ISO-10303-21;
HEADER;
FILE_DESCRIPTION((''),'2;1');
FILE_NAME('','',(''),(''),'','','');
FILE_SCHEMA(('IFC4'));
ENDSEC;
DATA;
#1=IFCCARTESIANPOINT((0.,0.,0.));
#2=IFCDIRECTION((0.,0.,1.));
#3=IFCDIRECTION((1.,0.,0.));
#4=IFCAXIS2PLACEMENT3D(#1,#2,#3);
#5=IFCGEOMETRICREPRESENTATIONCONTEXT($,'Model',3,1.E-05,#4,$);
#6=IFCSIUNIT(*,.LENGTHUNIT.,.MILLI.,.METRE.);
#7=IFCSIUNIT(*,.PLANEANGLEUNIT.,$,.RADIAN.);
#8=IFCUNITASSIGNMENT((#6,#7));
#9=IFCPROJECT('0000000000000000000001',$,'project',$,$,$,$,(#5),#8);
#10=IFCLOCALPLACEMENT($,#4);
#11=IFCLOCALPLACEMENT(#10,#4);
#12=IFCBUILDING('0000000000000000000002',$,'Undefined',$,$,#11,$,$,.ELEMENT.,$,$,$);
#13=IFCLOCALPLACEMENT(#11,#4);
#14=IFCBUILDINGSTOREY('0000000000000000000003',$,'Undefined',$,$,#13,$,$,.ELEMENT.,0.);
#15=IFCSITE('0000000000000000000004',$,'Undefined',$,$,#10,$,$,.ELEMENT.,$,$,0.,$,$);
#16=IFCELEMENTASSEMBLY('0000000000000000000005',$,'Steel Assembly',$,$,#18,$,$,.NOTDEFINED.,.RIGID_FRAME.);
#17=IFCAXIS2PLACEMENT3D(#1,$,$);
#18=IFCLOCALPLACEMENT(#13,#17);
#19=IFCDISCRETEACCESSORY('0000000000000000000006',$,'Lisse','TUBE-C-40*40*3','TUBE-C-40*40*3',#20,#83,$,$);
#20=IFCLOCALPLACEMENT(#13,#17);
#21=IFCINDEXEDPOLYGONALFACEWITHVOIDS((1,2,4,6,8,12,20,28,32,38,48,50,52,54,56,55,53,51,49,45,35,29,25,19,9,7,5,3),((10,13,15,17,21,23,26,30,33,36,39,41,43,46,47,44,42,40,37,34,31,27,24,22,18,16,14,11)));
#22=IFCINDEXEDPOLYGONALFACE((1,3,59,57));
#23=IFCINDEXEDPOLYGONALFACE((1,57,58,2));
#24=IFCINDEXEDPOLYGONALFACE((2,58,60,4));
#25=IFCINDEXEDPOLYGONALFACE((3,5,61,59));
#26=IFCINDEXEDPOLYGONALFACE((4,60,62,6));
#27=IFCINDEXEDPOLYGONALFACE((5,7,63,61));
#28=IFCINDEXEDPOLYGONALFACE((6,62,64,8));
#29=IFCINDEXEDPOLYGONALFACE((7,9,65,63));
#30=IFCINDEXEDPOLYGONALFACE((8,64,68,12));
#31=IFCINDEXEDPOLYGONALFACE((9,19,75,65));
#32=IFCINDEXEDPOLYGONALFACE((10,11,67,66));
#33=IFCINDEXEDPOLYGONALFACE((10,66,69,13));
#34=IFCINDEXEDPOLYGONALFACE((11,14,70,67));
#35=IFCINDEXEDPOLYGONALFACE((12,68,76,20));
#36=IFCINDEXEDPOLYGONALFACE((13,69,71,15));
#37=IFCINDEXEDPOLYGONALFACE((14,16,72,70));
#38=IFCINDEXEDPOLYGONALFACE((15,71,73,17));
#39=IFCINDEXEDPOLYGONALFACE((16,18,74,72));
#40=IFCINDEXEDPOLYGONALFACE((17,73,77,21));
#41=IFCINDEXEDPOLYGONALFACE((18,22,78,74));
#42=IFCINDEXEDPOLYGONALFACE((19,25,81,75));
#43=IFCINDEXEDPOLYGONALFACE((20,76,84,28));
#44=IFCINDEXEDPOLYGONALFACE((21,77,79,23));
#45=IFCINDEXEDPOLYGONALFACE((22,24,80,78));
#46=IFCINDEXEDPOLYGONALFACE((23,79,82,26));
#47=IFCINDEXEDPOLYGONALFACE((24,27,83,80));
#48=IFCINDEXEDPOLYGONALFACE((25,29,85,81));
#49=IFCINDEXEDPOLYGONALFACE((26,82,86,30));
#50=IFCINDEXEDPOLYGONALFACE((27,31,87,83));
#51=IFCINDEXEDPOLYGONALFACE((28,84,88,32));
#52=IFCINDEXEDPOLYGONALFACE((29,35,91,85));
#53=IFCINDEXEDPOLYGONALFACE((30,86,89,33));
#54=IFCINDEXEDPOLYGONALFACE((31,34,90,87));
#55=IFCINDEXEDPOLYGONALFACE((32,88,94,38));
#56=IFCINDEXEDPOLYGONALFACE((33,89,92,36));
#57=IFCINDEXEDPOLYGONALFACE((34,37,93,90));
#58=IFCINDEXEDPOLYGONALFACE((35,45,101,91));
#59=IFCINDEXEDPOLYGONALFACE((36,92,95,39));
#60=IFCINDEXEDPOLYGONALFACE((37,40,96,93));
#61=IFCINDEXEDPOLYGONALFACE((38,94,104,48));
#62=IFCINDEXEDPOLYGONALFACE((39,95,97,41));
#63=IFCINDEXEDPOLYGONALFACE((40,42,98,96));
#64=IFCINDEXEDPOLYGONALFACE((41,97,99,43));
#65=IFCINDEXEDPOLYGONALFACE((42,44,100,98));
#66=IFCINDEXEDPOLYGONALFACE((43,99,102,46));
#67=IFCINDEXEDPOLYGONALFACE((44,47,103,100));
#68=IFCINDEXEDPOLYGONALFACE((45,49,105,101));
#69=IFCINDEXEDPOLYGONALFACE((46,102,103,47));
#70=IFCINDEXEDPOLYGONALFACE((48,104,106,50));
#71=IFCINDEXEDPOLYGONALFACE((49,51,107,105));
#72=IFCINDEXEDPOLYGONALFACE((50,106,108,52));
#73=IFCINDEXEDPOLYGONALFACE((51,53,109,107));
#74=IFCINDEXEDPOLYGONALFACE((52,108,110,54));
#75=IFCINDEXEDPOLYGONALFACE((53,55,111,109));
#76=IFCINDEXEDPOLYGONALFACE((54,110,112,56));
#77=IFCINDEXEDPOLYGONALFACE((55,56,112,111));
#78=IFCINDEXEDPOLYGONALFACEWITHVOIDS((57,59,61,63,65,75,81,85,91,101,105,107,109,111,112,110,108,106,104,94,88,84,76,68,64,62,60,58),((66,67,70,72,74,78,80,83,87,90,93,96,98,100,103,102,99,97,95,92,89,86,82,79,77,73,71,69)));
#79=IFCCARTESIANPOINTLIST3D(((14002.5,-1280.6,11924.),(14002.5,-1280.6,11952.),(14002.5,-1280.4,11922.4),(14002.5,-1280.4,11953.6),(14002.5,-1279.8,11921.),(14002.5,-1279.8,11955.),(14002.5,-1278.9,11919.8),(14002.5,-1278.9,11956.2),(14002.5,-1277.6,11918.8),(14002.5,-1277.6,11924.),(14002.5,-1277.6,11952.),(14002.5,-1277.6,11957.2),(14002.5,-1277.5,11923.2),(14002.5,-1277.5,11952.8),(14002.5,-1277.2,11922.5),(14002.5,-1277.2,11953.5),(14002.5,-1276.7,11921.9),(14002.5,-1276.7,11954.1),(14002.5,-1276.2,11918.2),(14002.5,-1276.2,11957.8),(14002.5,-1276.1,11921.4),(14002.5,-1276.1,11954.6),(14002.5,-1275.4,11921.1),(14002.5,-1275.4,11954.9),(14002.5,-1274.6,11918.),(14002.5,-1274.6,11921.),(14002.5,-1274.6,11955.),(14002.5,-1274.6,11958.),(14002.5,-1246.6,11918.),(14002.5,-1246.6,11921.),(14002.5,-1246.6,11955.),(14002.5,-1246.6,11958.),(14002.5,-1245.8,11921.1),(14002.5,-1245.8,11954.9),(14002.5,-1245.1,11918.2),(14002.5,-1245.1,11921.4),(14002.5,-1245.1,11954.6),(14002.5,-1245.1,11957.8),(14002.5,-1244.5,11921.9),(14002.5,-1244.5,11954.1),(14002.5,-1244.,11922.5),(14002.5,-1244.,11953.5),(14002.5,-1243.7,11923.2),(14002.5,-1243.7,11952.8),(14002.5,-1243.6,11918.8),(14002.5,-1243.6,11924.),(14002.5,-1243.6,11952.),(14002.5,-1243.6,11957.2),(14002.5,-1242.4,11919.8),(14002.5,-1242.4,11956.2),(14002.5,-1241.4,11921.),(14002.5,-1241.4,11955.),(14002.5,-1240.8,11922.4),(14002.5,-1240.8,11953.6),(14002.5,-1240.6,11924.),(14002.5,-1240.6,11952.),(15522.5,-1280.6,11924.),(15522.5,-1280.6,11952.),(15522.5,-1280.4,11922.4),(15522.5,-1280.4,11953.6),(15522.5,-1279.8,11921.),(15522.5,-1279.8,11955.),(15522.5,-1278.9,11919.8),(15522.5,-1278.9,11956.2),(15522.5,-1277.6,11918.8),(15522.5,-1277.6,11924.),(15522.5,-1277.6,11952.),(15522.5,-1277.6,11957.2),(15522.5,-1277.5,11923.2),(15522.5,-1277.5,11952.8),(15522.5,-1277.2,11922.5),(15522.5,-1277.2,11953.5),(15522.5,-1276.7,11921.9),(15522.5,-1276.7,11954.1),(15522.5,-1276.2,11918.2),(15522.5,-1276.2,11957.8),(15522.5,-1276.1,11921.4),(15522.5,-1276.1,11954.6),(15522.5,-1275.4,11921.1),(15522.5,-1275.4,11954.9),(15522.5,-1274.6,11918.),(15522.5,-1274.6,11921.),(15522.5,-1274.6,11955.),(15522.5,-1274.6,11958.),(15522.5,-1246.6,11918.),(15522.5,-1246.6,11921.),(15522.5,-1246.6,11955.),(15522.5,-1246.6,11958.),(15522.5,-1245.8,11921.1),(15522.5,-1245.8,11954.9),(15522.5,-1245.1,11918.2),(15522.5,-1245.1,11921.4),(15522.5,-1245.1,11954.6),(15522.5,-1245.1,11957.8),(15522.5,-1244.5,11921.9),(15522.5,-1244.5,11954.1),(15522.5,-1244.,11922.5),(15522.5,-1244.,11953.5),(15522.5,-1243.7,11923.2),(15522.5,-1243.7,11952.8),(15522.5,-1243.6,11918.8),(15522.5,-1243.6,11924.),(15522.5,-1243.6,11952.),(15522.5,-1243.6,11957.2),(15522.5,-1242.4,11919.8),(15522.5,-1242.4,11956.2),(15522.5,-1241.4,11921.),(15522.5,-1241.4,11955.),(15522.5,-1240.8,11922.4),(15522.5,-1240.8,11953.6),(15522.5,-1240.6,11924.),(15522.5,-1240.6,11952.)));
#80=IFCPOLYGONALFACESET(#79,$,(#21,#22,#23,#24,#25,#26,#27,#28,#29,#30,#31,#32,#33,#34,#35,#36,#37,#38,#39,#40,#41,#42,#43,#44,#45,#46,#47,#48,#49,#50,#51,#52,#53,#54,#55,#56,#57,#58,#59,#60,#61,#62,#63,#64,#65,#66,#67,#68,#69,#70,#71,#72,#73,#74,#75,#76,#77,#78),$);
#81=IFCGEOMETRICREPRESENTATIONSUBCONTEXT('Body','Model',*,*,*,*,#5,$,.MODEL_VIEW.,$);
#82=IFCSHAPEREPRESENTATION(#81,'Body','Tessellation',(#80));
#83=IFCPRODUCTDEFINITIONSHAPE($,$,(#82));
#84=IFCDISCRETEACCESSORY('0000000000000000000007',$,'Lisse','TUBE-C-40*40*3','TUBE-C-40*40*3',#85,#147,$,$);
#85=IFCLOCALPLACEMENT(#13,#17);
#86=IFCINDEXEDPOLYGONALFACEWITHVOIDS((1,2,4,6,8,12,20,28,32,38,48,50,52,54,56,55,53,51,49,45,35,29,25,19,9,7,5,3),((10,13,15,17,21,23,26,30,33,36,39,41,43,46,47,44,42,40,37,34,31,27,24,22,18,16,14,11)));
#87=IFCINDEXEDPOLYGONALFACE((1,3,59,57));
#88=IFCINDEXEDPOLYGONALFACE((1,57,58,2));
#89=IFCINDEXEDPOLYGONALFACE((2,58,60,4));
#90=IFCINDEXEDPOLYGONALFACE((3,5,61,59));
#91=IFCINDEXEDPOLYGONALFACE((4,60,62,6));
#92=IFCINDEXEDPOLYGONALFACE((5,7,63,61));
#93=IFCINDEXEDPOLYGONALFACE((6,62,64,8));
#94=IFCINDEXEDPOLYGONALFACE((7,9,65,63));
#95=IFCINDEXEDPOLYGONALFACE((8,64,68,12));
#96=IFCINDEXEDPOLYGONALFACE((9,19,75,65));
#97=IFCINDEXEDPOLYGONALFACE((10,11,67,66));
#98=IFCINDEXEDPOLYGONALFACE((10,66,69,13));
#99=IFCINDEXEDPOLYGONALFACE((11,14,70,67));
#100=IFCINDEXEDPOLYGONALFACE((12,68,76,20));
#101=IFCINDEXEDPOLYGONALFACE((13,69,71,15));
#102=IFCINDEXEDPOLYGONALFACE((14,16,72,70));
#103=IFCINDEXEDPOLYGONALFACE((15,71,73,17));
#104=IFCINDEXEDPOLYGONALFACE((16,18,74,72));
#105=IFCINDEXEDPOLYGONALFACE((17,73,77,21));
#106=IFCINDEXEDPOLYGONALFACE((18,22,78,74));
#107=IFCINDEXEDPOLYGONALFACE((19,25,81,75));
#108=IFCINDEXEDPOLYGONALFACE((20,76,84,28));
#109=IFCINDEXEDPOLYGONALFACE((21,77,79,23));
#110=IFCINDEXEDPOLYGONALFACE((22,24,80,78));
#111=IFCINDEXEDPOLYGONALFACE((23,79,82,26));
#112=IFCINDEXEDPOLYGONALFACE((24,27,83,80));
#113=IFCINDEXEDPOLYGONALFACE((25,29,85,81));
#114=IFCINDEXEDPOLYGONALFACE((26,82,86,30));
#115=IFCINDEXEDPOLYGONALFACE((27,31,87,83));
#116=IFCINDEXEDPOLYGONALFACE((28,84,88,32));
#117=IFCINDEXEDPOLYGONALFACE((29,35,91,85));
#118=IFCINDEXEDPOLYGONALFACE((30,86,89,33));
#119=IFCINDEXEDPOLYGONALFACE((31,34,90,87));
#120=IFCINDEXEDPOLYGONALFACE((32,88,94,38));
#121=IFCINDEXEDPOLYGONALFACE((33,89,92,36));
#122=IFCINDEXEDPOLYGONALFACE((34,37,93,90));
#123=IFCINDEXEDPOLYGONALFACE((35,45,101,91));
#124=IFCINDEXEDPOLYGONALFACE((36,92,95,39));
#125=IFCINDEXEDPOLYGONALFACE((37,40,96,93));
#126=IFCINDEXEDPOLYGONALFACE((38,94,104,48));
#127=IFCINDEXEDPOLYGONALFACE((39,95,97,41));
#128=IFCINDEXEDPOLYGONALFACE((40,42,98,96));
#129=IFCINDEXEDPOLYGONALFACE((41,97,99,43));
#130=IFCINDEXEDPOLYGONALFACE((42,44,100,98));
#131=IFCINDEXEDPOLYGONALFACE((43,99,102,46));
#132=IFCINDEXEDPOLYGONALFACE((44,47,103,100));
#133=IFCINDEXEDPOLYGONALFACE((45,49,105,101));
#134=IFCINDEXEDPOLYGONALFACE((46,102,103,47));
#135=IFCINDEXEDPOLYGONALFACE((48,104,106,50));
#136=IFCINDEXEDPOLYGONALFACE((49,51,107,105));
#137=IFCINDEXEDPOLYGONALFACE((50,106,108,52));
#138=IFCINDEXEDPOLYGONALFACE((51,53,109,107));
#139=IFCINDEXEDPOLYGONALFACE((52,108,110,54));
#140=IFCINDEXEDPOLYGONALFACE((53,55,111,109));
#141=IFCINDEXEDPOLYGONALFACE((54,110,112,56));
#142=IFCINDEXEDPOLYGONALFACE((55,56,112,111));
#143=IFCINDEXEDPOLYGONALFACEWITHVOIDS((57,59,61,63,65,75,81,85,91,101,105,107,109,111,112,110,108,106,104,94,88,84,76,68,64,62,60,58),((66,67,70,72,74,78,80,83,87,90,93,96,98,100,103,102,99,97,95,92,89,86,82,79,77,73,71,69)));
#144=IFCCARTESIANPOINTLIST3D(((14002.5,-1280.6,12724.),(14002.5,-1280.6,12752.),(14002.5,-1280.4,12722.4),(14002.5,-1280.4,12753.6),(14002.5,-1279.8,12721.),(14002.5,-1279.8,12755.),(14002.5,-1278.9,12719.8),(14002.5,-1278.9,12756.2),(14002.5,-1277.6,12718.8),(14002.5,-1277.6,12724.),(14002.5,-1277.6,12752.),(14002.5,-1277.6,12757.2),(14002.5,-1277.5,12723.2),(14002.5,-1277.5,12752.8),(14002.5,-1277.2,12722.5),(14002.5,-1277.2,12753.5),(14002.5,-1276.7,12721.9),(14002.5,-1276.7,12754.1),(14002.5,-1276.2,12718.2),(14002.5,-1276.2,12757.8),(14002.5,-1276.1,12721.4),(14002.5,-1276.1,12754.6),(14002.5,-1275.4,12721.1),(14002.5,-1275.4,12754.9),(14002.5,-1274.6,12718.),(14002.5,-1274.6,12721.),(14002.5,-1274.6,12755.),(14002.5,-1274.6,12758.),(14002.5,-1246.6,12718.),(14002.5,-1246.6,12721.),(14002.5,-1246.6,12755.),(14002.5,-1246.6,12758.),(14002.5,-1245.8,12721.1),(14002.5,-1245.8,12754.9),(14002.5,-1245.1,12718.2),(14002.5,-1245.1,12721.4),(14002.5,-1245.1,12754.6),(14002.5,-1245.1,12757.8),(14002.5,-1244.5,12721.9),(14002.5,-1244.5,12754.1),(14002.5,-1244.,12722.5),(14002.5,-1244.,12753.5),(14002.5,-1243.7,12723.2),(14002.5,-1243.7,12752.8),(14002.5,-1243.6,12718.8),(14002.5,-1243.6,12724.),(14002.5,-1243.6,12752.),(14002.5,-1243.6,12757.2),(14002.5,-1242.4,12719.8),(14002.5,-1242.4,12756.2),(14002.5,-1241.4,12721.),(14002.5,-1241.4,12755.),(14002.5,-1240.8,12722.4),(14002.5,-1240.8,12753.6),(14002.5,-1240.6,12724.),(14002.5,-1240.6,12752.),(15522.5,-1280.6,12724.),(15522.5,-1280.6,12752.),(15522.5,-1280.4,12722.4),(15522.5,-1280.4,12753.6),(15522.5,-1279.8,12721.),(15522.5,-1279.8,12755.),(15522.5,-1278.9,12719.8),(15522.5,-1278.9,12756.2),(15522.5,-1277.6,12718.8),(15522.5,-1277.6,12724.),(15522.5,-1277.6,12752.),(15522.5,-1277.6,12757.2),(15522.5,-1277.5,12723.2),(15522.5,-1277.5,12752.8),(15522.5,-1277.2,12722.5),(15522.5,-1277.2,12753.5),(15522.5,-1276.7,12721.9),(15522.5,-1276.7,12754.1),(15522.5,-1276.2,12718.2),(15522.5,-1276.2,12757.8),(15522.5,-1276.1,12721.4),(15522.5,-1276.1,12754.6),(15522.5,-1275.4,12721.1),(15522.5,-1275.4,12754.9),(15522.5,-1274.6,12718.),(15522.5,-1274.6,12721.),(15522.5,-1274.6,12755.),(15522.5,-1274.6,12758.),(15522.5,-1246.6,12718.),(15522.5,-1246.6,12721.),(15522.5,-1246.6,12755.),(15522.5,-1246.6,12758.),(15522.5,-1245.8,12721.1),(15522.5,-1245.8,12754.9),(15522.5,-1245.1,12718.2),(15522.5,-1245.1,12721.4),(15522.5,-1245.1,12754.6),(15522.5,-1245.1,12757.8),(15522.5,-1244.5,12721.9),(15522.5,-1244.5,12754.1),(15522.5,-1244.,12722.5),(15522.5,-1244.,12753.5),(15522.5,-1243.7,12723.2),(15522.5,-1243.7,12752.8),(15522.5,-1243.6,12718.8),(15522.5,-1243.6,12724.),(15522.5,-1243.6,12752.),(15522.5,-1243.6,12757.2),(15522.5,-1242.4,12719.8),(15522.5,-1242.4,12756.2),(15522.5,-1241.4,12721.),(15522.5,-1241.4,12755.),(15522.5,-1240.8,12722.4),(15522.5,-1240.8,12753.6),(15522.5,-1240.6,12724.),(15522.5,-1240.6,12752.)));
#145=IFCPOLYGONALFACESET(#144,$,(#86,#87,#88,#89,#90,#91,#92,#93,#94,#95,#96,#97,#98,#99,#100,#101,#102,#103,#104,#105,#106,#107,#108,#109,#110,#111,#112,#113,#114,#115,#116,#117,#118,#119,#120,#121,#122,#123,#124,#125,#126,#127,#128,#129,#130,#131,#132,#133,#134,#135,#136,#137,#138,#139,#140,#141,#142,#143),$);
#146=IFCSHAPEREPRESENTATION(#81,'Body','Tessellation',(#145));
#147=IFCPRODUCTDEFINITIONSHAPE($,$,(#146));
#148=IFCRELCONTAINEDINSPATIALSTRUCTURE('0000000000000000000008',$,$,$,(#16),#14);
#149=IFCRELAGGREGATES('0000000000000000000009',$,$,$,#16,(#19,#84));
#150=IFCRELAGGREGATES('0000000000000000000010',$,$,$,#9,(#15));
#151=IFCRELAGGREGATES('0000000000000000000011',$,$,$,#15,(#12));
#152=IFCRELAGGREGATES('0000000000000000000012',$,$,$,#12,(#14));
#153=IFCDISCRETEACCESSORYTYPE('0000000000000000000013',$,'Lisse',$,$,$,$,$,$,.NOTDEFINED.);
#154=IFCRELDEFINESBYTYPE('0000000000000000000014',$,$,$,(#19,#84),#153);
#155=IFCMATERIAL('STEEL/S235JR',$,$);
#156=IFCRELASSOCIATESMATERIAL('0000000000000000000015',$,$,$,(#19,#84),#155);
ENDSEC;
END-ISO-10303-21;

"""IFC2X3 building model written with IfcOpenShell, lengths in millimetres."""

from ifc_helpers import new_model, si_unit, frame, origin_with_axes, origin_2d_with_axis, place, context, subcontext, project, spatial, hollow_rectangle, extrude, material, type_object, element, aggregate, save


model = new_model("IFC2X3")

# Units and contexts
model_context = context("Model", 3, precision=1e-05, world=origin_with_axes())
body_context = subcontext(model_context, "Body", "Model", "MODEL_VIEW")
ifc_project = project(units=[si_unit("LENGTHUNIT", "METRE", prefix="MILLI"), si_unit("PLANEANGLEUNIT", "RADIAN")], contexts=[model_context])

# Site, building, storey
site_placement = place(None, origin_with_axes())
site = spatial("IfcSite", under=ifc_project, at=site_placement, Name="Undefined", CompositionType="ELEMENT", RefElevation=0.0)
building_placement = place(site_placement, origin_with_axes())
building = spatial("IfcBuilding", under=site, at=building_placement, Name="Undefined", CompositionType="ELEMENT")
storey_placement = place(building_placement, origin_with_axes())
storey = spatial("IfcBuildingStorey", under=building, at=storey_placement, Name="Undefined", CompositionType="ELEMENT", Elevation=0.0)

# Shared definitions
ifc_material_1 = material(Name="STEEL/S235JR")

# Element assembly
assembly_1_placement = place(storey_placement, origin_with_axes())
assembly_1 = element("IfcElementAssembly", 1, at=assembly_1_placement, inside=storey, Name="Steel Assembly", AssemblyPlace="NOTDEFINED", PredefinedType="RIGID_FRAME")

# Discrete accessories
discrete_accessory_type_1 = type_object("IfcDiscreteAccessoryType", Name="Lisse")
discrete_accessory_1_placement = place(assembly_1_placement, frame((14002.5, -1260.6, 11938.0), z_axis=(0.0, 1.0, 0.0), x_axis=(1.0, 0.0, 0.0)))
discrete_accessory_1 = element("IfcDiscreteAccessory", 2, at=discrete_accessory_1_placement, type_object=discrete_accessory_type_1, material=ifc_material_1, Name="Lisse", Description="TUBE-C-40*40*3", ObjectType="TUBE-C-40*40*3", context=body_context, shape_type="SweptSolid", body=[
    extrude(hollow_rectangle(XDim=40.0, YDim=40.0, WallThickness=3.0, InnerFilletRadius=3.0, OuterFilletRadius=6.0, at=origin_2d_with_axis()), frame((1520.0, 0.0, 0.0), z_axis=(-1.0, 0.0, 0.0), x_axis=(0.0, -1.0, 0.0)), (0.0, 0.0, 1.0), 1520.0),
])
discrete_accessory_2_placement = place(assembly_1_placement, frame((14002.5, -1260.6, 12738.0), z_axis=(0.0, 1.0, 0.0), x_axis=(1.0, 0.0, 0.0)))
discrete_accessory_2 = element("IfcDiscreteAccessory", 3, at=discrete_accessory_2_placement, type_object=discrete_accessory_type_1, material=ifc_material_1, Name="Lisse", Description="TUBE-C-40*40*3", ObjectType="TUBE-C-40*40*3", context=body_context, shape_type="SweptSolid", body=[
    extrude(hollow_rectangle(XDim=40.0, YDim=40.0, WallThickness=3.0, InnerFilletRadius=3.0, OuterFilletRadius=6.0, at=origin_2d_with_axis()), frame((1520.0, 0.0, 0.0), z_axis=(-1.0, 0.0, 0.0), x_axis=(0.0, -1.0, 0.0)), (0.0, 0.0, 1.0), 1520.0),
])
aggregate(assembly_1, [discrete_accessory_1, discrete_accessory_2])

save(model, "model.ifc")
